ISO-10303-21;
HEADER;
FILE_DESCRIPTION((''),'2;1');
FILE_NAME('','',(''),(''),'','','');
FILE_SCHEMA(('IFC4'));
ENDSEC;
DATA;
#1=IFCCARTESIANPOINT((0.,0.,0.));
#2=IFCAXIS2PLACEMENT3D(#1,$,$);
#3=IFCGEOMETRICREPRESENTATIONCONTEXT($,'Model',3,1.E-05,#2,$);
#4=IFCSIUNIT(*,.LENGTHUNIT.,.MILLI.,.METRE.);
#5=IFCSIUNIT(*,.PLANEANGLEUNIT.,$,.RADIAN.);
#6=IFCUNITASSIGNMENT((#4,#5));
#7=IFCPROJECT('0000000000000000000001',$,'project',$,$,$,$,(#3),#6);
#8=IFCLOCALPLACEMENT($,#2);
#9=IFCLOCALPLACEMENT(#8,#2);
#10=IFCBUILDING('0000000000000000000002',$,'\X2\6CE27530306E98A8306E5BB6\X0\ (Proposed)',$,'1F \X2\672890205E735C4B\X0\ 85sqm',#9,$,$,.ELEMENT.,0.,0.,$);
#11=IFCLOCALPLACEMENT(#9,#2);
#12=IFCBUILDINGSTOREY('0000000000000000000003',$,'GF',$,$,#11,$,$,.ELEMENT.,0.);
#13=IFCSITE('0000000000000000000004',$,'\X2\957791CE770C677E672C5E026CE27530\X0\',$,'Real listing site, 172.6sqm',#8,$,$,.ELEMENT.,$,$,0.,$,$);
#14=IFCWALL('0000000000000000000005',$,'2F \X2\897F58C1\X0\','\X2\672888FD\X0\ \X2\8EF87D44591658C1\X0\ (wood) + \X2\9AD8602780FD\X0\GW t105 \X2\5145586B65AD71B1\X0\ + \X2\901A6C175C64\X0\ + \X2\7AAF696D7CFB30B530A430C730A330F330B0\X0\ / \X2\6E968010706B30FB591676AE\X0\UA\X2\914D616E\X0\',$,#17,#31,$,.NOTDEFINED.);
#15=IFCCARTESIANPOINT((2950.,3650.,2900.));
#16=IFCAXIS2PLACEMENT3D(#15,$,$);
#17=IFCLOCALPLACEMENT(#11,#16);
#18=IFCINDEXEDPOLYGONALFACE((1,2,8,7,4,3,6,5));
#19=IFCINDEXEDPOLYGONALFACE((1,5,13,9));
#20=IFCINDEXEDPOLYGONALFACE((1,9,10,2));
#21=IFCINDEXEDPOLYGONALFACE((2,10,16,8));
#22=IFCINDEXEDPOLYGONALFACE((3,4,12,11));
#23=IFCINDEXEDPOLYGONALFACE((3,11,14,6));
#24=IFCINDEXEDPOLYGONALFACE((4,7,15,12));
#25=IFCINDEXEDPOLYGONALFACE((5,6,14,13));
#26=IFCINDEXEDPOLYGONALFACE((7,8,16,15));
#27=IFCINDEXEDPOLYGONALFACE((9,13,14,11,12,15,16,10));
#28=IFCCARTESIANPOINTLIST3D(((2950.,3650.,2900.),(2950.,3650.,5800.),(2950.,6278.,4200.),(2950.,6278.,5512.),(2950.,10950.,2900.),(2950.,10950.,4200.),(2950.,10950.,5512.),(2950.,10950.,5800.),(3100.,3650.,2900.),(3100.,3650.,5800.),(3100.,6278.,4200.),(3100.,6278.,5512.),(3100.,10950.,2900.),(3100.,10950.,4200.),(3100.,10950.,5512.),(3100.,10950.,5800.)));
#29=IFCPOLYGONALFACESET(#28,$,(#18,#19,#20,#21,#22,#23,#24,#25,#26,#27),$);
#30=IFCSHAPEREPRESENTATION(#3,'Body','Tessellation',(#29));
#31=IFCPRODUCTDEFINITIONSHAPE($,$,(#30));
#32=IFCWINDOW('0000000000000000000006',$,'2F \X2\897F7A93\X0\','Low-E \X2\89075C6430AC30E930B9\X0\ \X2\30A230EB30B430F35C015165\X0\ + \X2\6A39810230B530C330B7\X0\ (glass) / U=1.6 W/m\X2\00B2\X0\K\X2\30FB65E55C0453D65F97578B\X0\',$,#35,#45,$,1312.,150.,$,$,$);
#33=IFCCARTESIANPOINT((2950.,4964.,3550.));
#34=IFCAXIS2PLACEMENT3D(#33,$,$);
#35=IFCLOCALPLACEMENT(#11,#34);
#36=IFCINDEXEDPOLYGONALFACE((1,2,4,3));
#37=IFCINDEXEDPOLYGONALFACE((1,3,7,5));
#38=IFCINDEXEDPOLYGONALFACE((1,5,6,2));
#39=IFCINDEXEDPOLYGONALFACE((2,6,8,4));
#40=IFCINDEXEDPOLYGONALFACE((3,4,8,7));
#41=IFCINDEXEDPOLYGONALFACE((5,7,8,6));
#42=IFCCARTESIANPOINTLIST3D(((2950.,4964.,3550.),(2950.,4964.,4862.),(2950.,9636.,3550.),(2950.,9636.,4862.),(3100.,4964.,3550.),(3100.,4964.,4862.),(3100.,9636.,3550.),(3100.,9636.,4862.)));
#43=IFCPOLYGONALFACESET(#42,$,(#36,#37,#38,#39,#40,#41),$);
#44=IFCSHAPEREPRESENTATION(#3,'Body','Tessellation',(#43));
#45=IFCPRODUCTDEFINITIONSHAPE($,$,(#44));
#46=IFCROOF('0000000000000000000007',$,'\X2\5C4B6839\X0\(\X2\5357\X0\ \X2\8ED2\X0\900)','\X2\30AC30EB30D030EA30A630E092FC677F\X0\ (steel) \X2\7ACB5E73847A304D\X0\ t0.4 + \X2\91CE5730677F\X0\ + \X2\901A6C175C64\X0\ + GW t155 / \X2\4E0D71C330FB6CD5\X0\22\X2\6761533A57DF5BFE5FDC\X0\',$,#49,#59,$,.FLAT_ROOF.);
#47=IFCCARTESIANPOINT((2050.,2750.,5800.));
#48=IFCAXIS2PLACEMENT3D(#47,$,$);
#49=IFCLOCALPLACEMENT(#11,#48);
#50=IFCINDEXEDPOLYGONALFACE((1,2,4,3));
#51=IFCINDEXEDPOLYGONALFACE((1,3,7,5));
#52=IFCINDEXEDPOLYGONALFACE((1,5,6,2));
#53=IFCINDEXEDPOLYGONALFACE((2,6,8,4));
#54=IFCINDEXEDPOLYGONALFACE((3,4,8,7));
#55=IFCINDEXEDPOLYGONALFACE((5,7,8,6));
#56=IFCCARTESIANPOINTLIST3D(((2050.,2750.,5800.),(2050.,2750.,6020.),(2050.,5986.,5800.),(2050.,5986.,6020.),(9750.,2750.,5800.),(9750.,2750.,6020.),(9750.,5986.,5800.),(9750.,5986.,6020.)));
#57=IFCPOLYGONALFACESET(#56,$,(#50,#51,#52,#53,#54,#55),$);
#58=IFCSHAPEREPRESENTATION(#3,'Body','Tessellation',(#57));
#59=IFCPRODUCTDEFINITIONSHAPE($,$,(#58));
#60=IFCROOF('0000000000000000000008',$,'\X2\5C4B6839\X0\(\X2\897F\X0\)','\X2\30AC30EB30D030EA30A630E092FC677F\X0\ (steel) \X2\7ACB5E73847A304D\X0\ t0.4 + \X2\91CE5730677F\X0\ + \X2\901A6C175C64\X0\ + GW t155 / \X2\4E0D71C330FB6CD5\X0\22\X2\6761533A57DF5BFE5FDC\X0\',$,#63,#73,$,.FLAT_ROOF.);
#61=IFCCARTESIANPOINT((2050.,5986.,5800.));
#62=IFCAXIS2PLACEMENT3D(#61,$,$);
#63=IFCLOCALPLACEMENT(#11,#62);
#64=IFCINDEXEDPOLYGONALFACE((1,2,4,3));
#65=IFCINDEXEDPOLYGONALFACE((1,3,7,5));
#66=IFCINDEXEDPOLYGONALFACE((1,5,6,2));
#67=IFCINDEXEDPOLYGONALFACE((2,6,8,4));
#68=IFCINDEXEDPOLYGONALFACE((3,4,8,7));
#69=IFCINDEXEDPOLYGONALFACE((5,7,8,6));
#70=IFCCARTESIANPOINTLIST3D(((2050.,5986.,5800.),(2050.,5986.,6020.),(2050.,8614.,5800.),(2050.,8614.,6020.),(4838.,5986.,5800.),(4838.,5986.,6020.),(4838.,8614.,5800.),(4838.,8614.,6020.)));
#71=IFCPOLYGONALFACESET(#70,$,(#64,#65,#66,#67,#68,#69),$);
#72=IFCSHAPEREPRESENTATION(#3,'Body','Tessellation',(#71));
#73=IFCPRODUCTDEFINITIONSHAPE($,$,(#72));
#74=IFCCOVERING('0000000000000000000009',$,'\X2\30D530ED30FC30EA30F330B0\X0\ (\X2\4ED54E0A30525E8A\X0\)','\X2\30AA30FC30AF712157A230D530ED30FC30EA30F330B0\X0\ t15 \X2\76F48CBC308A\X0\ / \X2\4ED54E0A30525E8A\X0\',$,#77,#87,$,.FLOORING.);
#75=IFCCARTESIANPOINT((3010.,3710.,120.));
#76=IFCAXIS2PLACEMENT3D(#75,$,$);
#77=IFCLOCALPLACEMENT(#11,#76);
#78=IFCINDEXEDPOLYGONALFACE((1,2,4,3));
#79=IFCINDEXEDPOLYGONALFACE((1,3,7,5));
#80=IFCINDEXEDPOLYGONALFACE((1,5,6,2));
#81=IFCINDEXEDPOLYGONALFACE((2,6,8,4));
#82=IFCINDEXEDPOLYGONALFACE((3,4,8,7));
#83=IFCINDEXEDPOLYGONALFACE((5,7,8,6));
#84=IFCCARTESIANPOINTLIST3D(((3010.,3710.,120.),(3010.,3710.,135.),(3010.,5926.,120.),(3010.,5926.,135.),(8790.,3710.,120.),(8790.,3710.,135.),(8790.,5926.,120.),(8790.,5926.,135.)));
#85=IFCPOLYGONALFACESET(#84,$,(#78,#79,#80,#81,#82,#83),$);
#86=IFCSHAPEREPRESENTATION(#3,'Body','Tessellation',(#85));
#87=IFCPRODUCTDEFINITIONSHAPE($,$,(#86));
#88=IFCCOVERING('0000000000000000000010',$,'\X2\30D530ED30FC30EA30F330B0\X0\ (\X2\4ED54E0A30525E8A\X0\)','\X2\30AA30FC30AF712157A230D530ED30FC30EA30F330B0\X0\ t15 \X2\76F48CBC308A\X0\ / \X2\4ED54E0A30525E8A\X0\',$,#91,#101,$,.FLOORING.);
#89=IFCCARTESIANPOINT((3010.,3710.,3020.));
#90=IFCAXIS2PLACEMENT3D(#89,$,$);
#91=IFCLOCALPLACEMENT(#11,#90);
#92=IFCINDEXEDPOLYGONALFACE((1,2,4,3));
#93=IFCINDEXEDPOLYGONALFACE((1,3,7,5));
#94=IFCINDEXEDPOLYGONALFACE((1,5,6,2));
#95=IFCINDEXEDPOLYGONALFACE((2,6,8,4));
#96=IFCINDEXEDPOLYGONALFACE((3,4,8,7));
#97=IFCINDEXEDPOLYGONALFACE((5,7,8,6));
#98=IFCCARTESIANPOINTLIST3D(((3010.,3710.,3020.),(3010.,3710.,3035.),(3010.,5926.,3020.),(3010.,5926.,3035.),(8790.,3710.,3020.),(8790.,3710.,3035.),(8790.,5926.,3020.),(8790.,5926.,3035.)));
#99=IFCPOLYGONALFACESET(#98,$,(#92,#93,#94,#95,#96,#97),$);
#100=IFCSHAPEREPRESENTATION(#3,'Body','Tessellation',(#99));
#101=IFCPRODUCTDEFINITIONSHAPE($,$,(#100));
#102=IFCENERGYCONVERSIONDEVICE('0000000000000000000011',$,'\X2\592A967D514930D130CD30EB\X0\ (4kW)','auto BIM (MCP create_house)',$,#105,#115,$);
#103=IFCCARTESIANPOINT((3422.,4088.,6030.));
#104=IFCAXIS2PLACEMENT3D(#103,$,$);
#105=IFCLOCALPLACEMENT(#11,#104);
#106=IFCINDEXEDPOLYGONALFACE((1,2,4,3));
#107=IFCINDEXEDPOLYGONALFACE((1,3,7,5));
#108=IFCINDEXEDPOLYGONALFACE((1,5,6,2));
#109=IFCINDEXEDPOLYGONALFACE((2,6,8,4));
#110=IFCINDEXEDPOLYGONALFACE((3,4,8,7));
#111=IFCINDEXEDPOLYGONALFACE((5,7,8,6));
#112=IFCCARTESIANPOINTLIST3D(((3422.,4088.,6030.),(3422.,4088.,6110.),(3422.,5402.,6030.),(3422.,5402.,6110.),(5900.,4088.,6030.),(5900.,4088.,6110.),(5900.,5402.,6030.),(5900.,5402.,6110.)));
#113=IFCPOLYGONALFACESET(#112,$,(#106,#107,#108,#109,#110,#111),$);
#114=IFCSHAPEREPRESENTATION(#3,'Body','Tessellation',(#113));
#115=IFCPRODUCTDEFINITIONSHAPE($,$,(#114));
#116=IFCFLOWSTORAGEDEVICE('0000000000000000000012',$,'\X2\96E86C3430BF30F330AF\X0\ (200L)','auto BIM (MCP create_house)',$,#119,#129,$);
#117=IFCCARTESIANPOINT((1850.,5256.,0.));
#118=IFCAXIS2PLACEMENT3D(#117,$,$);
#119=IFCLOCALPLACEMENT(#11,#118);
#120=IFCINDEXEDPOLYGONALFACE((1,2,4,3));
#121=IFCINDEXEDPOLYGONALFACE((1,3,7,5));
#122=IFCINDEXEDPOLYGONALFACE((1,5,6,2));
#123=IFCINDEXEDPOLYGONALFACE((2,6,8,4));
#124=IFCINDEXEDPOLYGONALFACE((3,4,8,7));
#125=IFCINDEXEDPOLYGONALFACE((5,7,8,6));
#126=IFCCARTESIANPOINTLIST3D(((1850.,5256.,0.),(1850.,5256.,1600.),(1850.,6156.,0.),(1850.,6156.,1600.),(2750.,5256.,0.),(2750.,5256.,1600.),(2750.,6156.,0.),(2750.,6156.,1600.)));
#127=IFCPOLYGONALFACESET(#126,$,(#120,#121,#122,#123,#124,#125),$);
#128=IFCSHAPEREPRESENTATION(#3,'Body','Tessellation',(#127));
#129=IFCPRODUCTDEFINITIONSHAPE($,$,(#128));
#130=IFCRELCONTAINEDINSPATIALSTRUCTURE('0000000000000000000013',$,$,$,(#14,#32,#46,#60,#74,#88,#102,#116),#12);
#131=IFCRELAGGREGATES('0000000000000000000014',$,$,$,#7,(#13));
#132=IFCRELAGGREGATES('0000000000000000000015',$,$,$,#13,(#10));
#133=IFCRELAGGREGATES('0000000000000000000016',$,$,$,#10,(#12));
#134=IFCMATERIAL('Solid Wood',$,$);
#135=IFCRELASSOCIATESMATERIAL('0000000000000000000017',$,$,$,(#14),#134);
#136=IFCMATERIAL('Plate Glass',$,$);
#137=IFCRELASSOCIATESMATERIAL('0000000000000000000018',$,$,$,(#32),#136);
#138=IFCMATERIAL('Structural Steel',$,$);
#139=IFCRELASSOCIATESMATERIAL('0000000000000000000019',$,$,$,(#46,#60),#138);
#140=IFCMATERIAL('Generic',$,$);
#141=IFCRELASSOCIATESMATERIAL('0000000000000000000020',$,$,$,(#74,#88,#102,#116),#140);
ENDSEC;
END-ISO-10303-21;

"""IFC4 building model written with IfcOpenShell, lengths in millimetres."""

from ifc_helpers import new_model, si_unit, frame, frame_2d, origin, place, context, project, spatial, rectangle, extrude, material, element, fill, save


model = new_model("IFC4")

# Units and contexts
model_context = context("Model", 3, precision=1e-05, world=origin())
ifc_project = project(units=[si_unit("LENGTHUNIT", "METRE", prefix="MILLI"), si_unit("PLANEANGLEUNIT", "RADIAN")], contexts=[model_context])

# Site, building, storey
site_placement = place(None, origin())
site = spatial("IfcSite", under=ifc_project, at=site_placement, Name="長野県松本市波田", ObjectType="Real listing site, 172.6sqm", CompositionType="ELEMENT", RefElevation=0.0)
building_placement = place(site_placement, origin())
building = spatial("IfcBuilding", under=site, at=building_placement, Name="波田の風の家 (Proposed)", ObjectType="1F 木造平屋 85sqm", CompositionType="ELEMENT", ElevationOfRefHeight=0.0, ElevationOfTerrain=0.0)
storey_placement = place(building_placement, origin())
storey = spatial("IfcBuildingStorey", under=building, at=storey_placement, Name="GF", CompositionType="ELEMENT", Elevation=0.0)

# Shared definitions
ifc_material_1 = material(Name="Solid Wood")
ifc_material_2 = material(Name="Generic")

# Shared definitions
ifc_material_3 = material(Name="Plate Glass")

# Wall, opening, window
wall_1_placement = place(storey_placement, frame((2950.0, 3650.0, 2900.0)))
wall_1 = element("IfcWall", 1, at=wall_1_placement, inside=storey, material=ifc_material_1, Name="2F 西壁", Description="木製 軸組外壁 (wood) + 高性能GW t105 充填断熱 + 通気層 + 窯業系サイディング / 準耐火・外皮UA配慮", PredefinedType="NOTDEFINED", context=model_context, shape_type="SweptSolid", body=[
    extrude(rectangle(XDim=150.0, YDim=7300.0, at=frame_2d((75.0, 3650.0))), frame((2950.0, 3650.0, 2900.0)), (0.0, 0.0, 1.0), 2900.0),
])
opening_1_placement = place(storey_placement, frame((2950.0, 4964.0, 3550.0)))
opening_1 = element("IfcOpeningElement", 2, at=opening_1_placement, cuts=wall_1, PredefinedType="NOTDEFINED", context=model_context, shape_type="SweptSolid", body=[
    extrude(rectangle(XDim=150.0, YDim=4672.0, at=frame_2d((75.0, 2336.0))), frame((2950.0, 4964.0, 3550.0)), (0.0, 0.0, 1.0), 1312.0),
])
window_1_placement = place(storey_placement, frame((2950.0, 4964.0, 3550.0)))
window_1 = element("IfcWindow", 3, at=window_1_placement, inside=storey, material=ifc_material_3, Name="2F 西窓", Description="Low-E 複層ガラス アルゴン封入 + 樹脂サッシ (glass) / U=1.6 W/m²K・日射取得型", OverallHeight=1312.0, OverallWidth=150.0, context=model_context, shape_type="SweptSolid", body=[
    extrude(rectangle(XDim=150.0, YDim=4672.0, at=frame_2d((75.0, 2336.0))), frame((2950.0, 4964.0, 3550.0)), (0.0, 0.0, 1.0), 1312.0),
])
fill(opening_1, window_1)

# Roofs
ifc_material_4 = material(Name="Structural Steel")
roof_1_placement = place(storey_placement, frame((2050.0, 2750.0, 5800.0)))
element("IfcRoof", 4, at=roof_1_placement, inside=storey, material=ifc_material_4, Name="屋根(南 軒900)", Description="ガルバリウム鋼板 (steel) 立平葺き t0.4 + 野地板 + 通気層 + GW t155 / 不燃・法22条区域対応", PredefinedType="FLAT_ROOF", context=model_context, shape_type="SweptSolid", body=[
    extrude(rectangle(XDim=7700.0, YDim=3236.0, at=frame_2d((3850.0, 1618.0))), frame((2050.0, 2750.0, 5800.0)), (0.0, 0.0, 1.0), 220.0),
])
roof_2_placement = place(storey_placement, frame((2050.0, 5986.0, 5800.0)))
element("IfcRoof", 5, at=roof_2_placement, inside=storey, material=ifc_material_4, Name="屋根(西)", Description="ガルバリウム鋼板 (steel) 立平葺き t0.4 + 野地板 + 通気層 + GW t155 / 不燃・法22条区域対応", PredefinedType="FLAT_ROOF", context=model_context, shape_type="SweptSolid", body=[
    extrude(rectangle(XDim=2788.0, YDim=2628.0, at=frame_2d((1394.0, 1314.0))), frame((2050.0, 5986.0, 5800.0)), (0.0, 0.0, 1.0), 220.0),
])

# Coverings
covering_1_placement = place(storey_placement, frame((3010.0, 3710.0, 120.0)))
element("IfcCovering", 6, at=covering_1_placement, inside=storey, material=ifc_material_2, Name="フローリング (仕上げ床)", Description="オーク無垢フローリング t15 直貼り / 仕上げ床", PredefinedType="FLOORING", context=model_context, shape_type="SweptSolid", body=[
    extrude(rectangle(XDim=5780.0, YDim=2216.0, at=frame_2d((2890.0, 1108.0))), frame((3010.0, 3710.0, 120.0)), (0.0, 0.0, 1.0), 15.0),
])
covering_2_placement = place(storey_placement, frame((3010.0, 3710.0, 3020.0)))
element("IfcCovering", 7, at=covering_2_placement, inside=storey, material=ifc_material_2, Name="フローリング (仕上げ床)", Description="オーク無垢フローリング t15 直貼り / 仕上げ床", PredefinedType="FLOORING", context=model_context, shape_type="SweptSolid", body=[
    extrude(rectangle(XDim=5780.0, YDim=2216.0, at=frame_2d((2890.0, 1108.0))), frame((3010.0, 3710.0, 3020.0)), (0.0, 0.0, 1.0), 15.0),
])

# Energy conversion device
energy_conversion_device_placement = place(storey_placement, frame((3422.0, 4088.0, 6030.0)))
element("IfcEnergyConversionDevice", 8, at=energy_conversion_device_placement, inside=storey, material=ifc_material_2, Name="太陽光パネル (4kW)", Description="auto BIM (MCP create_house)", context=model_context, shape_type="SweptSolid", body=[
    extrude(rectangle(XDim=2478.0, YDim=1314.0, at=frame_2d((1239.0, 657.0))), frame((3422.0, 4088.0, 6030.0)), (0.0, 0.0, 1.0), 80.0),
])

# Flow storage device
flow_storage_device_placement = place(storey_placement, frame((1850.0, 5256.0, 0.0)))
element("IfcFlowStorageDevice", 9, at=flow_storage_device_placement, inside=storey, material=ifc_material_2, Name="雨水タンク (200L)", Description="auto BIM (MCP create_house)", context=model_context, shape_type="SweptSolid", body=[
    extrude(rectangle(XDim=900.0, YDim=900.0, at=frame_2d((450.0, 450.0))), frame((1850.0, 5256.0, 0.0)), (0.0, 0.0, 1.0), 1600.0),
])

save(model, "model.ifc")
